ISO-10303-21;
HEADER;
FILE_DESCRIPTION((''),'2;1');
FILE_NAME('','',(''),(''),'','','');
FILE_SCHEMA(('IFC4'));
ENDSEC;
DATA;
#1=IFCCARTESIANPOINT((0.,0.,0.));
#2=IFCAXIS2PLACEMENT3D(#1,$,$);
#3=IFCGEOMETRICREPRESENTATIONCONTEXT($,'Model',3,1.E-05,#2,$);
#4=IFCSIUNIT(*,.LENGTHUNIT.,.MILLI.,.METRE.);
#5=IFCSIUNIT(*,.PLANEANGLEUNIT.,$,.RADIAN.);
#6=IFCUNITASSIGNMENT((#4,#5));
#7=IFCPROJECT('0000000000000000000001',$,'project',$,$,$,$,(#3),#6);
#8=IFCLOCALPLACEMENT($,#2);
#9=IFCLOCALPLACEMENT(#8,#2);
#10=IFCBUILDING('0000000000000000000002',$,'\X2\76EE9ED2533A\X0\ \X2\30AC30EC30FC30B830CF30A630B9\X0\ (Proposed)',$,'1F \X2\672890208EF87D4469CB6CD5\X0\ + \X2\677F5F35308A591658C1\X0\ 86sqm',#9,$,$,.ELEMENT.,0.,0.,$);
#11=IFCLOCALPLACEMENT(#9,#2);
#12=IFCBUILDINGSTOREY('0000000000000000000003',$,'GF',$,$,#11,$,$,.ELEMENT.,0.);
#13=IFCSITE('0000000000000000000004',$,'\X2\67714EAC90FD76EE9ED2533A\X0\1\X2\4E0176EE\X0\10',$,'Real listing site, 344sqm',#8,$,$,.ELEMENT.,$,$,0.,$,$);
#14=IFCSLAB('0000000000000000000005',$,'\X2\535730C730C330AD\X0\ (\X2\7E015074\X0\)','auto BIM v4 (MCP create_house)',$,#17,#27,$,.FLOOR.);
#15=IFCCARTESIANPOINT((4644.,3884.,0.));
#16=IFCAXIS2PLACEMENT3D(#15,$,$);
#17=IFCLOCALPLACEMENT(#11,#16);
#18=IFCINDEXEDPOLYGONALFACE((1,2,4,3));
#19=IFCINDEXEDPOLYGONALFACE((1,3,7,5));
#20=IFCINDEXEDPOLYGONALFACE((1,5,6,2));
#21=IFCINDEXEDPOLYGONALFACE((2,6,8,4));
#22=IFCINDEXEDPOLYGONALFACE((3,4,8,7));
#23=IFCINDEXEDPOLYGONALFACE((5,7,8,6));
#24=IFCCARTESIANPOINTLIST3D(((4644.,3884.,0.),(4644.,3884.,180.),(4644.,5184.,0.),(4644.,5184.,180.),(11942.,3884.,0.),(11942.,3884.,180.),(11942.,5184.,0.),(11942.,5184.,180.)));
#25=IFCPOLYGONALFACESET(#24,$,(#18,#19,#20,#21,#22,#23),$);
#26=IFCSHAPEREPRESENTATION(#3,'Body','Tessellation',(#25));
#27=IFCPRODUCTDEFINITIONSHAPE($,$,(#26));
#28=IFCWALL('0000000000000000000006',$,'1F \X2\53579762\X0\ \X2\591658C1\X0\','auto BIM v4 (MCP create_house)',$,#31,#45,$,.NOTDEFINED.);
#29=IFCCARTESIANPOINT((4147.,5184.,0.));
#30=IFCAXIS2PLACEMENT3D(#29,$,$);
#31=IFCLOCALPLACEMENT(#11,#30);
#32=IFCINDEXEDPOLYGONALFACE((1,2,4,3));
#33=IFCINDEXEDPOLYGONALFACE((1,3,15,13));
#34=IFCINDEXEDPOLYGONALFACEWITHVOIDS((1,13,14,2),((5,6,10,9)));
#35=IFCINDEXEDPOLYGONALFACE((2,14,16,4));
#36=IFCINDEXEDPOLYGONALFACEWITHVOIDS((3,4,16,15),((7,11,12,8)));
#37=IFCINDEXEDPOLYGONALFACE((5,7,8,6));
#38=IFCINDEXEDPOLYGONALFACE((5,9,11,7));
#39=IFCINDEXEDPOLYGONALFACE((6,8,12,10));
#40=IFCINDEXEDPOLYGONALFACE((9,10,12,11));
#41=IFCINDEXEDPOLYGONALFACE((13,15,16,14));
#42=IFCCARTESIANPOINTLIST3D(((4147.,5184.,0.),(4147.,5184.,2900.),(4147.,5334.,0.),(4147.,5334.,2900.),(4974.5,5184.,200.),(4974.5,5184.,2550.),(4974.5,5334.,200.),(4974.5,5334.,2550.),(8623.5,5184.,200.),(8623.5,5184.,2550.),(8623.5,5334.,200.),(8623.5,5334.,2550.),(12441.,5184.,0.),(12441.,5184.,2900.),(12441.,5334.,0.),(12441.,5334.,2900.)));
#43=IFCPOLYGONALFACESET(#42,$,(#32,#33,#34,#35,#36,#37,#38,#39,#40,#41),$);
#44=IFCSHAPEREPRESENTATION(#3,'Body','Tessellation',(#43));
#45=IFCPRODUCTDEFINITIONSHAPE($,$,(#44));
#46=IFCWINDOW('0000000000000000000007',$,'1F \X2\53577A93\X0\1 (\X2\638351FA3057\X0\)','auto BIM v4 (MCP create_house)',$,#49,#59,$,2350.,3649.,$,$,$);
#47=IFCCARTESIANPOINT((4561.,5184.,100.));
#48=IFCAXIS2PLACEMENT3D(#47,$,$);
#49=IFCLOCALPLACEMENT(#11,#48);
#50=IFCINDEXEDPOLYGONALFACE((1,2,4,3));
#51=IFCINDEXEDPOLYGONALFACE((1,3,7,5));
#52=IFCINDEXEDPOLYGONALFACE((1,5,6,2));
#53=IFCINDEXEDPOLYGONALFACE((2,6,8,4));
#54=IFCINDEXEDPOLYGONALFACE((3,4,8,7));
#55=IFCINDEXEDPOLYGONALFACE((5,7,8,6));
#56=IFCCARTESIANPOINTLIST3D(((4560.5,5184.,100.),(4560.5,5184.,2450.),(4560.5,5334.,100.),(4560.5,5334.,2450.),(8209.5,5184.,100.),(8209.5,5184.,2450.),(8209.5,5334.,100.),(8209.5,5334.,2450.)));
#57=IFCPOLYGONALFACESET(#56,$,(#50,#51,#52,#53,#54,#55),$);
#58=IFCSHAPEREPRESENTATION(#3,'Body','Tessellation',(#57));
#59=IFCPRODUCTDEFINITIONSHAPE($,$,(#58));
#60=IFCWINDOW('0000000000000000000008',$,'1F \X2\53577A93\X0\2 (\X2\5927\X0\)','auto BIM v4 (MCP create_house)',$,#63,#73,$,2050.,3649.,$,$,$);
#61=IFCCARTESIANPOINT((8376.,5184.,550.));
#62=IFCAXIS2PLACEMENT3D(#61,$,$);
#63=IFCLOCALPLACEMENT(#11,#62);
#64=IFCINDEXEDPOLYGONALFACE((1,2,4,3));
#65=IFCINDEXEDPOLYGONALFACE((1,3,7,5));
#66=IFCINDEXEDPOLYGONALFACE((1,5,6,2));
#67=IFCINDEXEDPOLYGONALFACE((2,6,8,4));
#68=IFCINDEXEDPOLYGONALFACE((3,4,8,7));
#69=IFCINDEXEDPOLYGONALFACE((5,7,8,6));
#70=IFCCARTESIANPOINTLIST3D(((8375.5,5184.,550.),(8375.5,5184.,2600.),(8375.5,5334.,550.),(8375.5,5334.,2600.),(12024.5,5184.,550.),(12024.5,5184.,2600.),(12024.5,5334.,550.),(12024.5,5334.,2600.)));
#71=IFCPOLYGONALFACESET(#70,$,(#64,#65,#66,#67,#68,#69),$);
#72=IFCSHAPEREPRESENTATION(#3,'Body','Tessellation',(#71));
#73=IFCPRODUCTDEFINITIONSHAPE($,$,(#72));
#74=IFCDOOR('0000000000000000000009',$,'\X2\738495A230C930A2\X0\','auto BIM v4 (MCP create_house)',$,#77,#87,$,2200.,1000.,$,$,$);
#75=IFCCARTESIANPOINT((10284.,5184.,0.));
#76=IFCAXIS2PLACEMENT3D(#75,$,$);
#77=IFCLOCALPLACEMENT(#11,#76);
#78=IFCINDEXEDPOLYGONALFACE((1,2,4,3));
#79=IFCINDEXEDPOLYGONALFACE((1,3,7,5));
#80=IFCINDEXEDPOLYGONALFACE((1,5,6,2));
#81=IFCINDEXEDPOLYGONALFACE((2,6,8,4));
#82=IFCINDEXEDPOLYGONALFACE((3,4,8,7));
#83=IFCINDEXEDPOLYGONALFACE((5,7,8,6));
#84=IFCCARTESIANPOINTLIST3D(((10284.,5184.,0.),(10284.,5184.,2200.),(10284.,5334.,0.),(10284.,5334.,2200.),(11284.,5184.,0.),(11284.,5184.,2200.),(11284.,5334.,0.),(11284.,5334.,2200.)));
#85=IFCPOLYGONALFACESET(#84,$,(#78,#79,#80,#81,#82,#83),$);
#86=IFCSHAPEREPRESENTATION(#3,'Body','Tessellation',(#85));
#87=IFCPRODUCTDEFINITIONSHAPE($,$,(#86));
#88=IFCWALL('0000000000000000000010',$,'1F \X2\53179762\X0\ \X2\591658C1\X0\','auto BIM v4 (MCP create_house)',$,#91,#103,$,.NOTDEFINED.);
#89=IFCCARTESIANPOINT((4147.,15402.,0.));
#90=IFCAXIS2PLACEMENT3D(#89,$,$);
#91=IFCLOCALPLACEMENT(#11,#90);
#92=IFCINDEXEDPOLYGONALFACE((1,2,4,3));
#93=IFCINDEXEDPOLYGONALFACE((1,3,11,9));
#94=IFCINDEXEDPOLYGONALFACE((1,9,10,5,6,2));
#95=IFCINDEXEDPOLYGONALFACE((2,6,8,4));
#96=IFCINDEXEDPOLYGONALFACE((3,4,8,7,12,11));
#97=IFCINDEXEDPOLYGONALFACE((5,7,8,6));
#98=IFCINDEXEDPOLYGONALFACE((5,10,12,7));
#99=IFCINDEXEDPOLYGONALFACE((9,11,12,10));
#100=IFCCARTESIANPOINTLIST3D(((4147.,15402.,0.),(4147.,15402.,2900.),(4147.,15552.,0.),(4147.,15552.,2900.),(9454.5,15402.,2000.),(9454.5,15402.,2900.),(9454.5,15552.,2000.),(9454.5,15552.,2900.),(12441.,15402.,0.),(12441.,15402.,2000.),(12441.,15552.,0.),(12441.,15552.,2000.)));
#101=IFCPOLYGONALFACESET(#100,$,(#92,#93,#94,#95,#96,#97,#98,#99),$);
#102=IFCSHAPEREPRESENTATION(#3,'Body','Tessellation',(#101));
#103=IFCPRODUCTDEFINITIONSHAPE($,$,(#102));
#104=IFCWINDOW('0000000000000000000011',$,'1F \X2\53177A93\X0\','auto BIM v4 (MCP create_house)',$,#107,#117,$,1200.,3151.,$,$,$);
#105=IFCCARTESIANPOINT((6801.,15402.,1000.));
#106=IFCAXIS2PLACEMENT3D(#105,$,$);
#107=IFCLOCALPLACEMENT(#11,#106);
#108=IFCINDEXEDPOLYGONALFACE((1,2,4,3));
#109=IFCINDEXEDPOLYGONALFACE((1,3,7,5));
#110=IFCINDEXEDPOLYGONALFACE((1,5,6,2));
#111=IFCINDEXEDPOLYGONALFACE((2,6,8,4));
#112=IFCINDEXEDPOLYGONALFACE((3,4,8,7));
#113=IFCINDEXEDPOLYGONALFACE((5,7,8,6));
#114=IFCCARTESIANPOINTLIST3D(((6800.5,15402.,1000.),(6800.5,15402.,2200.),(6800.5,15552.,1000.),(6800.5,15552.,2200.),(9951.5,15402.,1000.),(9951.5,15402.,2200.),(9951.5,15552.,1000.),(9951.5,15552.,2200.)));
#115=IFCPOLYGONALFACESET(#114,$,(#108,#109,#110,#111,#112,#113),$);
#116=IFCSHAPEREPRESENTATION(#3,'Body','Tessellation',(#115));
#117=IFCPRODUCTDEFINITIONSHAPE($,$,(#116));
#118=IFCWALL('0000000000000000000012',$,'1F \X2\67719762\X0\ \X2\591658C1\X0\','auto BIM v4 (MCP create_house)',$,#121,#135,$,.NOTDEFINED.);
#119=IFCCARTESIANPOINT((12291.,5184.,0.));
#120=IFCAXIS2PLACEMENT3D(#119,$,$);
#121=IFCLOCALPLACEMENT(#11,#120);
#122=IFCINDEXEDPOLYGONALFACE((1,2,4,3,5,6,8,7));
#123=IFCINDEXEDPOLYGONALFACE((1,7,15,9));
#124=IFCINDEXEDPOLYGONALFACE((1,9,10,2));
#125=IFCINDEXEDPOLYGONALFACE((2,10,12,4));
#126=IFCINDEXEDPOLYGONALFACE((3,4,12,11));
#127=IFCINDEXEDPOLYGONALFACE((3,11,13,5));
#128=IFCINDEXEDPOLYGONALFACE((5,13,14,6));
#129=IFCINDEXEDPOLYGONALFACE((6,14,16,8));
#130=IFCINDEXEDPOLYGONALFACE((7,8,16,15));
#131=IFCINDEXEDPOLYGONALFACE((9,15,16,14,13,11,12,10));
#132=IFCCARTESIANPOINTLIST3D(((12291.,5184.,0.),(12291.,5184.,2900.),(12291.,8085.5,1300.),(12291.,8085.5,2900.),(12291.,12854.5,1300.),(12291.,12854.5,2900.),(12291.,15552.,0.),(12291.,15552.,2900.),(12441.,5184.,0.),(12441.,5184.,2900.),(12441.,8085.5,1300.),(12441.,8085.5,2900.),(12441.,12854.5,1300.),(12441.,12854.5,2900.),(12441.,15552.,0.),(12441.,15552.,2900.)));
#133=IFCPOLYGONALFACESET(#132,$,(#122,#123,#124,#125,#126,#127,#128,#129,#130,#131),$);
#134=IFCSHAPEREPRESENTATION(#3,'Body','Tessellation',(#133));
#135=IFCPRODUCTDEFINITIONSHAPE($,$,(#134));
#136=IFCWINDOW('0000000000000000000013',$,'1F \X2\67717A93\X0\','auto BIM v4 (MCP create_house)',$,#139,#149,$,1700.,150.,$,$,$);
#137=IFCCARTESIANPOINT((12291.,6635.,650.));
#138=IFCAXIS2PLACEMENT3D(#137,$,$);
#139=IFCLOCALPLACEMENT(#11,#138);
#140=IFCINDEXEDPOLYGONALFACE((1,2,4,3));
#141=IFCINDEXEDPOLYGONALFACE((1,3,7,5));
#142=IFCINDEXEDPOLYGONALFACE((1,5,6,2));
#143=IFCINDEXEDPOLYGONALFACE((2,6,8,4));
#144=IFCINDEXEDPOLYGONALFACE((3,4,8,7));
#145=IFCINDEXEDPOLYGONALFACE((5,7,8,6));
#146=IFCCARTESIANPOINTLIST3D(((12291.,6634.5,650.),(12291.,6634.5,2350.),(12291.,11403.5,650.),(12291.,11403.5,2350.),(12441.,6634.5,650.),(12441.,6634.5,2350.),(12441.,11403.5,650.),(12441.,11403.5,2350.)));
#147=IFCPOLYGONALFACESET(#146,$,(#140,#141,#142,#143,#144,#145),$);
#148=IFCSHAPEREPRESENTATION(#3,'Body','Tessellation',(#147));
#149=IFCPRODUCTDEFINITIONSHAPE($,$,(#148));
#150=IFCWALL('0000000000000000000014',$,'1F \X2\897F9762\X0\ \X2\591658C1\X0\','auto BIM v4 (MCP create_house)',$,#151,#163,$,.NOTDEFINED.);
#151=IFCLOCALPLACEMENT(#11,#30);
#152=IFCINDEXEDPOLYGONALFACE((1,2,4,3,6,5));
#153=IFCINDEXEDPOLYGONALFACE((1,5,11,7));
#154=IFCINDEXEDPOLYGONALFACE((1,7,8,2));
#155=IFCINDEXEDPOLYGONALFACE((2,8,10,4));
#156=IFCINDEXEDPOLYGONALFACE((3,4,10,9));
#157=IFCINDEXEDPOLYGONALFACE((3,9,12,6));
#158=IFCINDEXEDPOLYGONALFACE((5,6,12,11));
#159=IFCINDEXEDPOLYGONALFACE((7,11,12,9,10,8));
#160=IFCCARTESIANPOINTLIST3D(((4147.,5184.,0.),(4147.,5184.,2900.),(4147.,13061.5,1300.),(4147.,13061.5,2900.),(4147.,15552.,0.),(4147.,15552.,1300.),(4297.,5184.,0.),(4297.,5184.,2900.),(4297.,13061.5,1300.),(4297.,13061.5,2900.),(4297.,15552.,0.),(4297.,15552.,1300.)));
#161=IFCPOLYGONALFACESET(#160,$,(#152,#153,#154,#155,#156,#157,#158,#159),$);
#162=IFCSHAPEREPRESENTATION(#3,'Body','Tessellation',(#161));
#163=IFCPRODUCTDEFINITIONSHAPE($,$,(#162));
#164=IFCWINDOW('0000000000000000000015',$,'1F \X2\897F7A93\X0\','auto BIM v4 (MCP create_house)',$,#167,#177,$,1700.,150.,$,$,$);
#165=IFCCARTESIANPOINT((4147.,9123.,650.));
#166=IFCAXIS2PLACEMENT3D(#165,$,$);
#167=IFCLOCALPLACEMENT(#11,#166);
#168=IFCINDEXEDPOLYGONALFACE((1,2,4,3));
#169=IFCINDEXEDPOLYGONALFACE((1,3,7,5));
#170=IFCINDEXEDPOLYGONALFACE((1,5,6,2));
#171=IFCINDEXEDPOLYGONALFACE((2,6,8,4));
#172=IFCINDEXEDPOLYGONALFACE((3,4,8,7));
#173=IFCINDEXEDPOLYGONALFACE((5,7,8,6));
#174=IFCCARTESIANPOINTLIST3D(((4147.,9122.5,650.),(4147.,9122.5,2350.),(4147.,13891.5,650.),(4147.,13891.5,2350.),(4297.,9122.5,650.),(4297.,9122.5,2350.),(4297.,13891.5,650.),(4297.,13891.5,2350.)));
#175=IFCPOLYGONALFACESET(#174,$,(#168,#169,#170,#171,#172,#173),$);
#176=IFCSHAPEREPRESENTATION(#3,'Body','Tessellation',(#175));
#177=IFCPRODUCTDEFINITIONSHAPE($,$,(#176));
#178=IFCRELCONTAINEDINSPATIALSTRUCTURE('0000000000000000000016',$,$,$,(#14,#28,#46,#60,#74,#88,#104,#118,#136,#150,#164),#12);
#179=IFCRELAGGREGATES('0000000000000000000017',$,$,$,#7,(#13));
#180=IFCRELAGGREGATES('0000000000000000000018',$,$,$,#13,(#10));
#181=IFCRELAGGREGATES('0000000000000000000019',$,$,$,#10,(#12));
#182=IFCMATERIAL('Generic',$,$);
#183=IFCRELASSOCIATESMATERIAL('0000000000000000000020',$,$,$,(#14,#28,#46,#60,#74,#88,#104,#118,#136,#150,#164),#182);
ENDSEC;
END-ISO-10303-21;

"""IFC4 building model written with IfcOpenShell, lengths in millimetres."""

from ifc_helpers import new_model, si_unit, frame, frame_2d, origin, place, context, project, spatial, rectangle, extrude, material, element, fill, save


model = new_model("IFC4")

# Units and contexts
model_context = context("Model", 3, precision=1e-05, world=origin())
ifc_project = project(units=[si_unit("LENGTHUNIT", "METRE", prefix="MILLI"), si_unit("PLANEANGLEUNIT", "RADIAN")], contexts=[model_context])

# Site, building, storey
site_placement = place(None, origin())
site = spatial("IfcSite", under=ifc_project, at=site_placement, Name="東京都目黒区1丁目10", ObjectType="Real listing site, 344sqm", CompositionType="ELEMENT", RefElevation=0.0)
building_placement = place(site_placement, origin())
building = spatial("IfcBuilding", under=site, at=building_placement, Name="目黒区 ガレージハウス (Proposed)", ObjectType="1F 木造軸組構法 + 板張り外壁 86sqm", CompositionType="ELEMENT", ElevationOfRefHeight=0.0, ElevationOfTerrain=0.0)
storey_placement = place(building_placement, origin())
storey = spatial("IfcBuildingStorey", under=building, at=storey_placement, Name="GF", CompositionType="ELEMENT", Elevation=0.0)

# Slab
ifc_material = material(Name="Generic")
slab_1_placement = place(storey_placement, frame((4644.0, 3884.0, 0.0)))
element("IfcSlab", 1, at=slab_1_placement, inside=storey, material=ifc_material, Name="南デッキ (縁側)", Description="auto BIM v4 (MCP create_house)", PredefinedType="FLOOR", context=model_context, shape_type="SweptSolid", body=[
    extrude(rectangle(XDim=7298.0, YDim=1300.0, at=frame_2d((3649.0, 650.0))), frame((4644.0, 3884.0, 0.0)), (0.0, 0.0, 1.0), 180.0),
])

# Wall, openings, windows, door
wall_1_placement = place(storey_placement, frame((4147.0, 5184.0, 0.0)))
wall_1 = element("IfcWall", 2, at=wall_1_placement, inside=storey, material=ifc_material, Name="1F 南面 外壁", Description="auto BIM v4 (MCP create_house)", PredefinedType="NOTDEFINED", context=model_context, shape_type="SweptSolid", body=[
    extrude(rectangle(XDim=8294.0, YDim=150.0, at=frame_2d((4147.0, 75.0))), frame((4147.0, 5184.0, 0.0)), (0.0, 0.0, 1.0), 2900.0),
])
opening_1_placement = place(storey_placement, frame((4561.0, 5184.0, 100.0)))
opening_1 = element("IfcOpeningElement", 3, at=opening_1_placement, cuts=wall_1, PredefinedType="NOTDEFINED", context=model_context, shape_type="SweptSolid", body=[
    extrude(rectangle(XDim=3649.0, YDim=150.0, at=frame_2d((1824.0, 75.0))), frame((4561.0, 5184.0, 100.0)), (0.0, 0.0, 1.0), 2350.0),
])
opening_2_placement = place(storey_placement, frame((8376.0, 5184.0, 550.0)))
opening_2 = element("IfcOpeningElement", 4, at=opening_2_placement, cuts=wall_1, PredefinedType="NOTDEFINED", context=model_context, shape_type="SweptSolid", body=[
    extrude(rectangle(XDim=3649.0, YDim=150.0, at=frame_2d((1824.0, 75.0))), frame((8376.0, 5184.0, 550.0)), (0.0, 0.0, 1.0), 2050.0),
])
opening_3_placement = place(storey_placement, frame((10284.0, 5184.0, 0.0)))
opening_3 = element("IfcOpeningElement", 5, at=opening_3_placement, cuts=wall_1, PredefinedType="NOTDEFINED", context=model_context, shape_type="SweptSolid", body=[
    extrude(rectangle(XDim=1000.0, YDim=150.0, at=frame_2d((500.0, 75.0))), frame((10284.0, 5184.0, 0.0)), (0.0, 0.0, 1.0), 2200.0),
])
window_1_placement = place(storey_placement, frame((4561.0, 5184.0, 100.0)))
window_1 = element("IfcWindow", 6, at=window_1_placement, inside=storey, material=ifc_material, Name="1F 南窓1 (掃出し)", Description="auto BIM v4 (MCP create_house)", OverallHeight=2350.0, OverallWidth=3649.0, context=model_context, shape_type="SweptSolid", body=[
    extrude(rectangle(XDim=3649.0, YDim=150.0, at=frame_2d((1824.0, 75.0))), frame((4561.0, 5184.0, 100.0)), (0.0, 0.0, 1.0), 2350.0),
])
fill(opening_1, window_1)
window_2_placement = place(storey_placement, frame((8376.0, 5184.0, 550.0)))
window_2 = element("IfcWindow", 7, at=window_2_placement, inside=storey, material=ifc_material, Name="1F 南窓2 (大)", Description="auto BIM v4 (MCP create_house)", OverallHeight=2050.0, OverallWidth=3649.0, context=model_context, shape_type="SweptSolid", body=[
    extrude(rectangle(XDim=3649.0, YDim=150.0, at=frame_2d((1824.0, 75.0))), frame((8376.0, 5184.0, 550.0)), (0.0, 0.0, 1.0), 2050.0),
])
fill(opening_2, window_2)
door_placement = place(storey_placement, frame((10284.0, 5184.0, 0.0)))
door = element("IfcDoor", 8, at=door_placement, inside=storey, material=ifc_material, Name="玄関ドア", Description="auto BIM v4 (MCP create_house)", OverallHeight=2200.0, OverallWidth=1000.0, context=model_context, shape_type="SweptSolid", body=[
    extrude(rectangle(XDim=1000.0, YDim=150.0, at=frame_2d((500.0, 75.0))), frame((10284.0, 5184.0, 0.0)), (0.0, 0.0, 1.0), 2200.0),
])
fill(opening_3, door)

# Walls, openings, windows
wall_2_placement = place(storey_placement, frame((4147.0, 15402.0, 0.0)))
wall_2 = element("IfcWall", 9, at=wall_2_placement, inside=storey, material=ifc_material, Name="1F 北面 外壁", Description="auto BIM v4 (MCP create_house)", PredefinedType="NOTDEFINED", context=model_context, shape_type="SweptSolid", body=[
    extrude(rectangle(XDim=8294.0, YDim=150.0, at=frame_2d((4147.0, 75.0))), frame((4147.0, 15402.0, 0.0)), (0.0, 0.0, 1.0), 2900.0),
])
opening_4_placement = place(storey_placement, frame((6801.0, 15402.0, 1000.0)))
opening_4 = element("IfcOpeningElement", 10, at=opening_4_placement, cuts=wall_2, PredefinedType="NOTDEFINED", context=model_context, shape_type="SweptSolid", body=[
    extrude(rectangle(XDim=3151.0, YDim=150.0, at=frame_2d((1575.0, 75.0))), frame((6801.0, 15402.0, 1000.0)), (0.0, 0.0, 1.0), 1200.0),
])
window_3_placement = place(storey_placement, frame((6801.0, 15402.0, 1000.0)))
window_3 = element("IfcWindow", 11, at=window_3_placement, inside=storey, material=ifc_material, Name="1F 北窓", Description="auto BIM v4 (MCP create_house)", OverallHeight=1200.0, OverallWidth=3151.0, context=model_context, shape_type="SweptSolid", body=[
    extrude(rectangle(XDim=3151.0, YDim=150.0, at=frame_2d((1575.0, 75.0))), frame((6801.0, 15402.0, 1000.0)), (0.0, 0.0, 1.0), 1200.0),
])
fill(opening_4, window_3)
wall_3_placement = place(storey_placement, frame((12291.0, 5184.0, 0.0)))
wall_3 = element("IfcWall", 12, at=wall_3_placement, inside=storey, material=ifc_material, Name="1F 東面 外壁", Description="auto BIM v4 (MCP create_house)", PredefinedType="NOTDEFINED", context=model_context, shape_type="SweptSolid", body=[
    extrude(rectangle(XDim=150.0, YDim=10368.0, at=frame_2d((75.0, 5184.0))), frame((12291.0, 5184.0, 0.0)), (0.0, 0.0, 1.0), 2900.0),
])
opening_5_placement = place(storey_placement, frame((12291.0, 6635.0, 650.0)))
opening_5 = element("IfcOpeningElement", 13, at=opening_5_placement, cuts=wall_3, PredefinedType="NOTDEFINED", context=model_context, shape_type="SweptSolid", body=[
    extrude(rectangle(XDim=150.0, YDim=4769.0, at=frame_2d((75.0, 2384.0))), frame((12291.0, 6635.0, 650.0)), (0.0, 0.0, 1.0), 1700.0),
])
window_4_placement = place(storey_placement, frame((12291.0, 6635.0, 650.0)))
window_4 = element("IfcWindow", 14, at=window_4_placement, inside=storey, material=ifc_material, Name="1F 東窓", Description="auto BIM v4 (MCP create_house)", OverallHeight=1700.0, OverallWidth=150.0, context=model_context, shape_type="SweptSolid", body=[
    extrude(rectangle(XDim=150.0, YDim=4769.0, at=frame_2d((75.0, 2384.0))), frame((12291.0, 6635.0, 650.0)), (0.0, 0.0, 1.0), 1700.0),
])
fill(opening_5, window_4)
wall_4_placement = place(storey_placement, frame((4147.0, 5184.0, 0.0)))
wall_4 = element("IfcWall", 15, at=wall_4_placement, inside=storey, material=ifc_material, Name="1F 西面 外壁", Description="auto BIM v4 (MCP create_house)", PredefinedType="NOTDEFINED", context=model_context, shape_type="SweptSolid", body=[
    extrude(rectangle(XDim=150.0, YDim=10368.0, at=frame_2d((75.0, 5184.0))), frame((4147.0, 5184.0, 0.0)), (0.0, 0.0, 1.0), 2900.0),
])
opening_6_placement = place(storey_placement, frame((4147.0, 9123.0, 650.0)))
opening_6 = element("IfcOpeningElement", 16, at=opening_6_placement, cuts=wall_4, PredefinedType="NOTDEFINED", context=model_context, shape_type="SweptSolid", body=[
    extrude(rectangle(XDim=150.0, YDim=4769.0, at=frame_2d((75.0, 2384.0))), frame((4147.0, 9123.0, 650.0)), (0.0, 0.0, 1.0), 1700.0),
])
window_5_placement = place(storey_placement, frame((4147.0, 9123.0, 650.0)))
window_5 = element("IfcWindow", 17, at=window_5_placement, inside=storey, material=ifc_material, Name="1F 西窓", Description="auto BIM v4 (MCP create_house)", OverallHeight=1700.0, OverallWidth=150.0, context=model_context, shape_type="SweptSolid", body=[
    extrude(rectangle(XDim=150.0, YDim=4769.0, at=frame_2d((75.0, 2384.0))), frame((4147.0, 9123.0, 650.0)), (0.0, 0.0, 1.0), 1700.0),
])
fill(opening_6, window_5)

save(model, "model.ifc")
